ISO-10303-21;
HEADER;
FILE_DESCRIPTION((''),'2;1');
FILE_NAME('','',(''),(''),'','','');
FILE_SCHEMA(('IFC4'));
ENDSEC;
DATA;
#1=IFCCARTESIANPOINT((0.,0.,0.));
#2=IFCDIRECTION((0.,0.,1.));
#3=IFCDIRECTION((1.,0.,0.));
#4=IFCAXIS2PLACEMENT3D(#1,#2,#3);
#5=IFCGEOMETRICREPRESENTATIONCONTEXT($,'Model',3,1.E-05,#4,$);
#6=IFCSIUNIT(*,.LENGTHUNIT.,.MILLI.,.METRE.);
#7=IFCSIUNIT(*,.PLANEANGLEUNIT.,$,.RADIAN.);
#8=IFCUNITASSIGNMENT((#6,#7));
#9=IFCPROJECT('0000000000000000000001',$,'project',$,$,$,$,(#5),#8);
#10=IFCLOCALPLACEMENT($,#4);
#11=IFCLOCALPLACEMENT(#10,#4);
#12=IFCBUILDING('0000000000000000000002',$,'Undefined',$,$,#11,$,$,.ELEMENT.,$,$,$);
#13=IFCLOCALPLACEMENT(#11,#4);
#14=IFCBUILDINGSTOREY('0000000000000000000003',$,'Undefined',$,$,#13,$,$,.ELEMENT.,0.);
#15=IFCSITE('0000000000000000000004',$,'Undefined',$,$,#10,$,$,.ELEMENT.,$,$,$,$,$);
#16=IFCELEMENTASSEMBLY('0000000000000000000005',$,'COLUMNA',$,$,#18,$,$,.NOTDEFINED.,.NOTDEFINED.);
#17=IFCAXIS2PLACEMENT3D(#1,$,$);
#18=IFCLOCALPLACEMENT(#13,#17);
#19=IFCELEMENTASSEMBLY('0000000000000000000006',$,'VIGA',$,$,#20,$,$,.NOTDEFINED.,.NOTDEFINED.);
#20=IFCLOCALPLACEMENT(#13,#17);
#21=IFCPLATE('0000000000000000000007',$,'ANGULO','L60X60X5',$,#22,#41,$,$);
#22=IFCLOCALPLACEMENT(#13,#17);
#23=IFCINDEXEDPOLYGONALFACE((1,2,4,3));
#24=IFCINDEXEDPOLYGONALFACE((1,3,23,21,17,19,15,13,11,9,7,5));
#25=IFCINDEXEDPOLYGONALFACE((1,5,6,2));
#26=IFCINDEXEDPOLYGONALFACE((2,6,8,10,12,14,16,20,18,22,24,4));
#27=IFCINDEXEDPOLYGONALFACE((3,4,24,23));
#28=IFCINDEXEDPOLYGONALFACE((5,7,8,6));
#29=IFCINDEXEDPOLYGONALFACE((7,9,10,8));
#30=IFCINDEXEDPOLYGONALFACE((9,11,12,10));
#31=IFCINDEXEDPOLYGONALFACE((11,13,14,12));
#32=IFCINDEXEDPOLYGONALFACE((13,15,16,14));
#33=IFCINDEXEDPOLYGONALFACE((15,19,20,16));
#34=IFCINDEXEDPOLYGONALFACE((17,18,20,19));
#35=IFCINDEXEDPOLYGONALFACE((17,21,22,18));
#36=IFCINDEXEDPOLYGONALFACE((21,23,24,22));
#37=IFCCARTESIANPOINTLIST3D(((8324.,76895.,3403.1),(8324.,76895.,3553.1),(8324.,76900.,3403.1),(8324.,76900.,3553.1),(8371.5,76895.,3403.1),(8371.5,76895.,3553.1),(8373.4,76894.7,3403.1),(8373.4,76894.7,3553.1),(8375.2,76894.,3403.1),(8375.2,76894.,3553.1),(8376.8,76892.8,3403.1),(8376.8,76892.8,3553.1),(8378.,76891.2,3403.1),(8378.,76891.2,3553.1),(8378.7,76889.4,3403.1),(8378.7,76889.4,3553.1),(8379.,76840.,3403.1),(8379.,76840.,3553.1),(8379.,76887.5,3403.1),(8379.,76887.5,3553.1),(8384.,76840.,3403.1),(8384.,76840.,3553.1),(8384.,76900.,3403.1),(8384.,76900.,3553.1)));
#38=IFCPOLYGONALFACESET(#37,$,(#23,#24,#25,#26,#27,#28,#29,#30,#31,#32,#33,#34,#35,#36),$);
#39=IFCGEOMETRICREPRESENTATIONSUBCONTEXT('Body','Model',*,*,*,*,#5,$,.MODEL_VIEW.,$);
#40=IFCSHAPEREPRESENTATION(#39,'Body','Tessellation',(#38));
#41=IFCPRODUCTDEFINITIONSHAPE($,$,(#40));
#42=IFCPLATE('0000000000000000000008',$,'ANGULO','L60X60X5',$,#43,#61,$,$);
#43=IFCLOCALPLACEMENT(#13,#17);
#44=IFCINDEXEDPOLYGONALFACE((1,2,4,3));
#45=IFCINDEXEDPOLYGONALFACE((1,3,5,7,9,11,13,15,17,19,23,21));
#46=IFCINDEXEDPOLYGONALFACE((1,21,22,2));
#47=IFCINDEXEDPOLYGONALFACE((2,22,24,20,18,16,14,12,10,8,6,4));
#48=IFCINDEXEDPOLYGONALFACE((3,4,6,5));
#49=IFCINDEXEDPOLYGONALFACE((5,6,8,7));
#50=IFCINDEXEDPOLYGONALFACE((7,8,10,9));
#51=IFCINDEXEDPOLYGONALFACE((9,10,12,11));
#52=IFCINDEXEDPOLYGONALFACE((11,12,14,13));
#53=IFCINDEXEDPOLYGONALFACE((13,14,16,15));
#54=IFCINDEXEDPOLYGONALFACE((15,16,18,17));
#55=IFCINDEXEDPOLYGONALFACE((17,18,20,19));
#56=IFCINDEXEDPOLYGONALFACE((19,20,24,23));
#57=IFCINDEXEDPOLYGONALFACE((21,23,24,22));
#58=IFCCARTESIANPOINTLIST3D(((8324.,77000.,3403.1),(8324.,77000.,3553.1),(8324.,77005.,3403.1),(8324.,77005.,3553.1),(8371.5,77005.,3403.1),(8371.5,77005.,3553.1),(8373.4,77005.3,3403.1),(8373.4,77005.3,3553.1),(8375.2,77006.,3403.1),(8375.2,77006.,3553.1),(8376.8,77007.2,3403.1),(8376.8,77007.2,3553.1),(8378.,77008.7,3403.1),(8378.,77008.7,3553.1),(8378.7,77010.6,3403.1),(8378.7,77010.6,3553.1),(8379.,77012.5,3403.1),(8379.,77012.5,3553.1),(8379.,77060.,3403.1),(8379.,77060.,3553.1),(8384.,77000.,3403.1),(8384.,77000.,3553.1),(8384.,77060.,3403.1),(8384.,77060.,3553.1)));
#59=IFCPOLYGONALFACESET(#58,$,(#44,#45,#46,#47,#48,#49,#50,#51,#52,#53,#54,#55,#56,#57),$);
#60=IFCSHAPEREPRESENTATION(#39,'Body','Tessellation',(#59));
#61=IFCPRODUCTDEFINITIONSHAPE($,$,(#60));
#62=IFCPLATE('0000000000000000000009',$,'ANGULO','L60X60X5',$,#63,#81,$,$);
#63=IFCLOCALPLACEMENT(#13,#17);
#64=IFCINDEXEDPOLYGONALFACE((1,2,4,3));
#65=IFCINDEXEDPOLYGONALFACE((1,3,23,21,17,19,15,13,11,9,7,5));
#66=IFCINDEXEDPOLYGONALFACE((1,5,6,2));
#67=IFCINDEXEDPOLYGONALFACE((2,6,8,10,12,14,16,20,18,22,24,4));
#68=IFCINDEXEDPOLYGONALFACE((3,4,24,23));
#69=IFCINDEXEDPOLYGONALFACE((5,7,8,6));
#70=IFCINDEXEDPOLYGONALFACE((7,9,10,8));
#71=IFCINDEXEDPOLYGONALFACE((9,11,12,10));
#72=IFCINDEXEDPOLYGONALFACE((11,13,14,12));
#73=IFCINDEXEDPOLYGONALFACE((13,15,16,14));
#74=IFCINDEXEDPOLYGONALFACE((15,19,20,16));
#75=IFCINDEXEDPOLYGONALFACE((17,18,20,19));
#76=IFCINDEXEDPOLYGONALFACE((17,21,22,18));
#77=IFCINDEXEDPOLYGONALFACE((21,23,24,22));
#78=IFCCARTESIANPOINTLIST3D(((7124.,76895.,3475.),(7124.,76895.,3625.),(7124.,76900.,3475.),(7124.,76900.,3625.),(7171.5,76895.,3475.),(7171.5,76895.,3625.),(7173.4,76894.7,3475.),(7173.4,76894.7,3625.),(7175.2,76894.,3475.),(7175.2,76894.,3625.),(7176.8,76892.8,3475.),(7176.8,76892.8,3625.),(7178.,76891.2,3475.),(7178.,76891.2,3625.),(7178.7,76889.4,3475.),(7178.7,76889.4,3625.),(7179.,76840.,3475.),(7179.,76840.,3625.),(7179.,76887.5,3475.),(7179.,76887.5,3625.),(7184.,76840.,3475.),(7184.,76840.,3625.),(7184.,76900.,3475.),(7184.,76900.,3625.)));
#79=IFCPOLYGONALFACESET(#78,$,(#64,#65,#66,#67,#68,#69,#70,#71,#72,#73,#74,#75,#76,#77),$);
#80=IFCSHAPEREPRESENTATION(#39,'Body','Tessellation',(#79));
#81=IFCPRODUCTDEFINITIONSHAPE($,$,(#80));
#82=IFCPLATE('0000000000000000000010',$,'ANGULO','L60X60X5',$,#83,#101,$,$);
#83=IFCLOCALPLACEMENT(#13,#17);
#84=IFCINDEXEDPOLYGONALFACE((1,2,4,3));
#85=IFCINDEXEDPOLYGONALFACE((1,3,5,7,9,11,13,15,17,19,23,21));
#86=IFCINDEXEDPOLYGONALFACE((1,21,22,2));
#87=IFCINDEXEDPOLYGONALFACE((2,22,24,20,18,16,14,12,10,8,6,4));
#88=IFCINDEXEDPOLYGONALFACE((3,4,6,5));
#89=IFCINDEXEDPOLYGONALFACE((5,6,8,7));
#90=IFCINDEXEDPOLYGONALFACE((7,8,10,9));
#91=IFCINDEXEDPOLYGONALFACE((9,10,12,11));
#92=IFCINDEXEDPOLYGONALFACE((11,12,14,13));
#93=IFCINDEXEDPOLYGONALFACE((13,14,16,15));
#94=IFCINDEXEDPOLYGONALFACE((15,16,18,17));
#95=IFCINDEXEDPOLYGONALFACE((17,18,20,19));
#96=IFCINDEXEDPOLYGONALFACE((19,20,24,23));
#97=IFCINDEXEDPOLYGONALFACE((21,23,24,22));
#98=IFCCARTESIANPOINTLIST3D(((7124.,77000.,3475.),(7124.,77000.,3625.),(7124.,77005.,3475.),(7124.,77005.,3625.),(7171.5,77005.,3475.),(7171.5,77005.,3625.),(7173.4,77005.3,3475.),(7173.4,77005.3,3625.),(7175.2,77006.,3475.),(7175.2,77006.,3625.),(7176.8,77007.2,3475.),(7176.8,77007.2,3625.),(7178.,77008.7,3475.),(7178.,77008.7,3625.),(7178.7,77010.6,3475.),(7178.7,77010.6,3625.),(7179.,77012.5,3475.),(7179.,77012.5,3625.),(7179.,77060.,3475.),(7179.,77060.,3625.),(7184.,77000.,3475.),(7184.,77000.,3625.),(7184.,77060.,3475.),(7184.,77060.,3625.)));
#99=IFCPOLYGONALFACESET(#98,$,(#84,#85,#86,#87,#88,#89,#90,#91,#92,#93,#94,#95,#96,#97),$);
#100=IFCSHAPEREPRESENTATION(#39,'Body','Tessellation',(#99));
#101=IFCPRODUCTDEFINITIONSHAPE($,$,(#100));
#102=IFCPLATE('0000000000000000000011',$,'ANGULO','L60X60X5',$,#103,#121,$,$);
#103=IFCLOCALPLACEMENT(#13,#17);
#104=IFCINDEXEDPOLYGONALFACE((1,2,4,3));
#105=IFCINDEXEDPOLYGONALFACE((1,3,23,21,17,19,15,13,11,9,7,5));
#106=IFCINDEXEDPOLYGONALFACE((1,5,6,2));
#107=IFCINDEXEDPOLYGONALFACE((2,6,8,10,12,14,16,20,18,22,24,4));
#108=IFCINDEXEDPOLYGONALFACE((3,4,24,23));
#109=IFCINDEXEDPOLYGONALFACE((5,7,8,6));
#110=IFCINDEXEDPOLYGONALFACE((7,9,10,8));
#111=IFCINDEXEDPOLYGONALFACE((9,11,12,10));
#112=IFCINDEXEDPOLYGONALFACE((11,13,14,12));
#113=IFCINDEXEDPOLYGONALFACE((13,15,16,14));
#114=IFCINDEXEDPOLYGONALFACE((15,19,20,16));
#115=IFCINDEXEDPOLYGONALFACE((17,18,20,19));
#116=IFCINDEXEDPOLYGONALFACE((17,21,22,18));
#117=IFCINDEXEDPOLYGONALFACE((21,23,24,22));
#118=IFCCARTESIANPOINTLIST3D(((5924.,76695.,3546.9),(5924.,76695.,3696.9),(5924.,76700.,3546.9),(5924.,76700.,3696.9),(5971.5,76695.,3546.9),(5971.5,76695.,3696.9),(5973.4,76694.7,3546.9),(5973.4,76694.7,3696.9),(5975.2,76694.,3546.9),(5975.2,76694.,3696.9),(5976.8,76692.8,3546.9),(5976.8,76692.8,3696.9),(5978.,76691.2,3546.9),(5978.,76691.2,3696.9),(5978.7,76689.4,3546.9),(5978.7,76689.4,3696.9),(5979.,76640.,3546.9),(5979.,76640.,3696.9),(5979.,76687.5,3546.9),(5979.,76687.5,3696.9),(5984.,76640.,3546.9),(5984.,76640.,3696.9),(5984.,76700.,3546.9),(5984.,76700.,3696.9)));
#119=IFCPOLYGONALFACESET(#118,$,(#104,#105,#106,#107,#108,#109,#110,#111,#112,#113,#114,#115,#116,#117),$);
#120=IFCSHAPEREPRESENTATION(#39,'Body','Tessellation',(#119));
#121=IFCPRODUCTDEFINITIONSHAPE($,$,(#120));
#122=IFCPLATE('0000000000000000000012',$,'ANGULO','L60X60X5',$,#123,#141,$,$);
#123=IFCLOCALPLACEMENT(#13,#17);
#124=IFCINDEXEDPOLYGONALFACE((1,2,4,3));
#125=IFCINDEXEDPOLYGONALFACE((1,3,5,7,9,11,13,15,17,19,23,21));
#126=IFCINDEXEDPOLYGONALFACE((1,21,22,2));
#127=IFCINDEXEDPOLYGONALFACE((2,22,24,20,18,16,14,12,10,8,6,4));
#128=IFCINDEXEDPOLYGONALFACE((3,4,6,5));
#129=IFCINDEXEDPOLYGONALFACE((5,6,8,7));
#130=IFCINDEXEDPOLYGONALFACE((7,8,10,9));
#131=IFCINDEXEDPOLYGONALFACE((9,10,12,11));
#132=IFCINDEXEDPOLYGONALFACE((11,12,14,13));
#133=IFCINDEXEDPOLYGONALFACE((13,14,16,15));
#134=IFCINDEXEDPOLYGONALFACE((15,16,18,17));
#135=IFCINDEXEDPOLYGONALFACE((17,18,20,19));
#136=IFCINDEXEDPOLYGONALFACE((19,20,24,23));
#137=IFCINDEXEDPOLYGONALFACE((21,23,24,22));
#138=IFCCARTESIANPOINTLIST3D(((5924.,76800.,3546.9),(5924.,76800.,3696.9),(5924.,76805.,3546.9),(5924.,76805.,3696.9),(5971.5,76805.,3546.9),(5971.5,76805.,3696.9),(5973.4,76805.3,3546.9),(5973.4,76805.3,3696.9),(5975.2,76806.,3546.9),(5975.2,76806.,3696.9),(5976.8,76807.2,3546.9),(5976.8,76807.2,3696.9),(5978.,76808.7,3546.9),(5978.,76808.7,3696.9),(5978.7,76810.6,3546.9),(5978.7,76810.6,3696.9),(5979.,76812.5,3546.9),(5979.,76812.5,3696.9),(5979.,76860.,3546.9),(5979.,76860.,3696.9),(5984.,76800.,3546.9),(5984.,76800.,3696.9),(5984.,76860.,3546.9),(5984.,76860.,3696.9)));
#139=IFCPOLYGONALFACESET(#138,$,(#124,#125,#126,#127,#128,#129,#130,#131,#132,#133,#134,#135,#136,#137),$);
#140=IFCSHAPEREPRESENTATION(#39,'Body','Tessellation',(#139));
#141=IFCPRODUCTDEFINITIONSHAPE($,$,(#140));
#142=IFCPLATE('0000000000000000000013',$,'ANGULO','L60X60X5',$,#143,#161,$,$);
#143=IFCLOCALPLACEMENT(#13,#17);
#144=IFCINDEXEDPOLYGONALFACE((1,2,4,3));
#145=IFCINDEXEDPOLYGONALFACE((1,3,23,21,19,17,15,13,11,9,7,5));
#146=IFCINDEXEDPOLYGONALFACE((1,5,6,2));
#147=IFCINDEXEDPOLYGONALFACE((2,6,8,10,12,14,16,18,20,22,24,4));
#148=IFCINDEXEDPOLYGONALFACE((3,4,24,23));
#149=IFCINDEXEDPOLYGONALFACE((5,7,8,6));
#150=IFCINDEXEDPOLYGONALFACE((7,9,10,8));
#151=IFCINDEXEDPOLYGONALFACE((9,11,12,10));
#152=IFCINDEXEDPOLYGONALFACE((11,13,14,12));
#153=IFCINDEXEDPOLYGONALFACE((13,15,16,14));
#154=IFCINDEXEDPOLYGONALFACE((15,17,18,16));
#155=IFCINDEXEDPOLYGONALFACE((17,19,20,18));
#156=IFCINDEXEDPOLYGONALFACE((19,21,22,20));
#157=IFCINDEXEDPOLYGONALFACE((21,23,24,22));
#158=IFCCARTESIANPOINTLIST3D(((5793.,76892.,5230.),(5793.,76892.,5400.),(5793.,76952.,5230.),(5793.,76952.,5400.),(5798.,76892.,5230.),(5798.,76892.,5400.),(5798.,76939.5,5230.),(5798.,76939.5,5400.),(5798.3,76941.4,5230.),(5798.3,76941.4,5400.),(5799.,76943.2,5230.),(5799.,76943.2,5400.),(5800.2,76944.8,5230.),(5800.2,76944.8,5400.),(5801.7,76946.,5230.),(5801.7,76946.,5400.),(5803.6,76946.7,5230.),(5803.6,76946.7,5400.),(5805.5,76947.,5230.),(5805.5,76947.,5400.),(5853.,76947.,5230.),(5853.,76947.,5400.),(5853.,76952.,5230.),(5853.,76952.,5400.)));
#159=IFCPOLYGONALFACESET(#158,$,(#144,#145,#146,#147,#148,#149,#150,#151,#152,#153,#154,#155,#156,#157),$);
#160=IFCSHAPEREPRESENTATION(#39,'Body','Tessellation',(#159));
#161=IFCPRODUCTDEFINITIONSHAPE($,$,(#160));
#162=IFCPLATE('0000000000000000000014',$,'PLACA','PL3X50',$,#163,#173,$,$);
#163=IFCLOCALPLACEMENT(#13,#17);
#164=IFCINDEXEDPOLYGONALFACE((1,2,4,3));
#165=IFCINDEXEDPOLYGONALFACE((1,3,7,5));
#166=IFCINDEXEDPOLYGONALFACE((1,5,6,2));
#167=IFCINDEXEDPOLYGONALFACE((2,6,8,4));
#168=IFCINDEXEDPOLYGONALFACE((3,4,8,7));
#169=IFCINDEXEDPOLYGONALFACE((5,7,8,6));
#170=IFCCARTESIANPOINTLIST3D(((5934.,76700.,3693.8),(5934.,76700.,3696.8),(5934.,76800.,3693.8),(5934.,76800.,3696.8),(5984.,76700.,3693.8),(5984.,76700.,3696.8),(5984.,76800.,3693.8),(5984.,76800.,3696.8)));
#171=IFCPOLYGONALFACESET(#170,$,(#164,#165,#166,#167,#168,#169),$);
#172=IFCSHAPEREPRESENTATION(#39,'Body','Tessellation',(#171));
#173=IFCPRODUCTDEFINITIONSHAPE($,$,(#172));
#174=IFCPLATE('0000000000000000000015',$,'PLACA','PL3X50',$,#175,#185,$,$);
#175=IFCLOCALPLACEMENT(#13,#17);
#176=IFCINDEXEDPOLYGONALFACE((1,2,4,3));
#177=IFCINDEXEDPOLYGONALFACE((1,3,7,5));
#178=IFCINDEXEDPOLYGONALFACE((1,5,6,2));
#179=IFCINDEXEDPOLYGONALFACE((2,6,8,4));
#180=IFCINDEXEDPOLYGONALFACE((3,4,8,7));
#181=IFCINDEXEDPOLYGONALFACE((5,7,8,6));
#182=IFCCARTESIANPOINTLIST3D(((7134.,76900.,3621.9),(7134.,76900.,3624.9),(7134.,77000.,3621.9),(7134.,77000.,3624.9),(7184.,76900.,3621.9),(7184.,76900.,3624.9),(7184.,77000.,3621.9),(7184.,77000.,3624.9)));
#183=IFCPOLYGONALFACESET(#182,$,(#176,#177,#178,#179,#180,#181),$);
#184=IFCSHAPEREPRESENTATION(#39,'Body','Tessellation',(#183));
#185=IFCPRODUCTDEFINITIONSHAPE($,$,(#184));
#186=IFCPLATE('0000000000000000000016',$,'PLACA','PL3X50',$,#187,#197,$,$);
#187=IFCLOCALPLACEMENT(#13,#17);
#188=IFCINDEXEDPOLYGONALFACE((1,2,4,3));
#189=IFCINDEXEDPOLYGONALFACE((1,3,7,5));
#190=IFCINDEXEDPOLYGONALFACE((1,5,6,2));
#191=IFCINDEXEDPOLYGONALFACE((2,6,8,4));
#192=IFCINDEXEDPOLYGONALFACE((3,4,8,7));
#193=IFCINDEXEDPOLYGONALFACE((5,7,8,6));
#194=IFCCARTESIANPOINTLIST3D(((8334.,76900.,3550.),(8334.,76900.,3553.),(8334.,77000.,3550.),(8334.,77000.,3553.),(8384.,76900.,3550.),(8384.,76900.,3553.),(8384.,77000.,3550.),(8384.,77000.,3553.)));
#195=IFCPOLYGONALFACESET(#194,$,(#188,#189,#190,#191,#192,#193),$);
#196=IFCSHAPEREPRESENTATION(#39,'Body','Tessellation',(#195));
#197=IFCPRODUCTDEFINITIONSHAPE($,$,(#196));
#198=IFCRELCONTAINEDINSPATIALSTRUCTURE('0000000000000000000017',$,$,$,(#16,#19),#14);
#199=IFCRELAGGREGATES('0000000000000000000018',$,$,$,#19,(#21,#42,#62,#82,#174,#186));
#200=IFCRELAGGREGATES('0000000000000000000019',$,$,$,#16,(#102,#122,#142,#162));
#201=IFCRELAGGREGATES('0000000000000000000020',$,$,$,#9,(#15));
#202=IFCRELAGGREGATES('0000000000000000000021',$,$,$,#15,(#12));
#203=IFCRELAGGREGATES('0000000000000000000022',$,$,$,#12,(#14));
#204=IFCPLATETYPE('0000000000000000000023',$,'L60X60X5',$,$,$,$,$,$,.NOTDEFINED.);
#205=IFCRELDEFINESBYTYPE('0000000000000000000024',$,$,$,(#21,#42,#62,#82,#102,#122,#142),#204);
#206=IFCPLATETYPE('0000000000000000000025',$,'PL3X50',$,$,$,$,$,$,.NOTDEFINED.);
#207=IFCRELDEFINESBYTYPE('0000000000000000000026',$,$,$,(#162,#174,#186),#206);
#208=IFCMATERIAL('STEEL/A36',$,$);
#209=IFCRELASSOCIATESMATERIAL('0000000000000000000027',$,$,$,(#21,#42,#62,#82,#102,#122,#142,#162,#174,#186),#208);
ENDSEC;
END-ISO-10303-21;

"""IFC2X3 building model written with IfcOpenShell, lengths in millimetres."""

from ifc_helpers import new_model, si_unit, frame, origin_with_axes, origin_2d_with_axis, place, context, subcontext, project, spatial, polyline, l_section, outline, extrude, material, type_object, element, aggregate, save


model = new_model("IFC2X3")

# Units and contexts
model_context = context("Model", 3, precision=1e-05, world=origin_with_axes())
body_context = subcontext(model_context, "Body", "Model", "MODEL_VIEW")
ifc_project = project(units=[si_unit("LENGTHUNIT", "METRE", prefix="MILLI"), si_unit("PLANEANGLEUNIT", "RADIAN")], contexts=[model_context])

# Site, building, storey
site_placement = place(None, origin_with_axes())
site = spatial("IfcSite", under=ifc_project, at=site_placement, Name="Undefined", CompositionType="ELEMENT")
building_placement = place(site_placement, origin_with_axes())
building = spatial("IfcBuilding", under=site, at=building_placement, Name="Undefined", CompositionType="ELEMENT")
storey_placement = place(building_placement, origin_with_axes())
storey = spatial("IfcBuildingStorey", under=building, at=storey_placement, Name="Undefined", CompositionType="ELEMENT", Elevation=0.0)

# Element assembly
assembly_1_placement = place(storey_placement, origin_with_axes())
assembly_1 = element("IfcElementAssembly", 1, at=assembly_1_placement, inside=storey, Name="COLUMNA", AssemblyPlace="NOTDEFINED", PredefinedType="NOTDEFINED")
ifc_material_1 = material(Name="STEEL/A36")

# Element assembly, plates
assembly_2_placement = place(storey_placement, origin_with_axes())
assembly_2 = element("IfcElementAssembly", 2, at=assembly_2_placement, inside=storey, Name="VIGA", AssemblyPlace="NOTDEFINED", PredefinedType="NOTDEFINED")
plate_type_1 = type_object("IfcPlateType", Name="L60X60X5", PredefinedType="NOTDEFINED")
plate_1_placement = place(assembly_2_placement, frame((8354.0, 76870.0, 3403.1), z_axis=(-1.0, 0.0, 0.0), x_axis=(0.0, 0.0, 1.0)))
plate_1 = element("IfcPlate", 3, at=plate_1_placement, type_object=plate_type_1, material=ifc_material_1, Name="ANGULO", Description="L60X60X5", context=body_context, shape_type="SweptSolid", body=[
    extrude(l_section(Depth=60.0, Width=60.0, Thickness=5.0, FilletRadius=7.5, at=origin_2d_with_axis()), frame((150.0, 0.0, 0.0), z_axis=(-1.0, 0.0, 0.0), x_axis=(0.0, -1.0, 0.0)), (0.0, 0.0, 1.0), 150.0),
])
plate_2_placement = place(assembly_2_placement, frame((8354.0, 77030.0, 3553.1), z_axis=(-1.0, 0.0, 0.0), x_axis=(0.0, 0.0, -1.0)))
plate_2 = element("IfcPlate", 4, at=plate_2_placement, type_object=plate_type_1, material=ifc_material_1, Name="ANGULO", Description="L60X60X5", context=body_context, shape_type="SweptSolid", body=[
    extrude(l_section(Depth=60.0, Width=60.0, Thickness=5.0, FilletRadius=7.5, at=origin_2d_with_axis()), frame((150.0, 0.0, 0.0), z_axis=(-1.0, 0.0, 0.0), x_axis=(0.0, -1.0, 0.0)), (0.0, 0.0, 1.0), 150.0),
])
plate_3_placement = place(assembly_2_placement, frame((7154.0, 76870.0, 3475.0), z_axis=(-1.0, 0.0, 0.0), x_axis=(0.0, 0.0, 1.0)))
plate_3 = element("IfcPlate", 5, at=plate_3_placement, type_object=plate_type_1, material=ifc_material_1, Name="ANGULO", Description="L60X60X5", context=body_context, shape_type="SweptSolid", body=[
    extrude(l_section(Depth=60.0, Width=60.0, Thickness=5.0, FilletRadius=7.5, at=origin_2d_with_axis()), frame((150.0, 0.0, 0.0), z_axis=(-1.0, 0.0, 0.0), x_axis=(0.0, -1.0, 0.0)), (0.0, 0.0, 1.0), 150.0),
])
plate_4_placement = place(assembly_2_placement, frame((7154.0, 77030.0, 3625.0), z_axis=(-1.0, 0.0, 0.0), x_axis=(0.0, 0.0, -1.0)))
plate_4 = element("IfcPlate", 6, at=plate_4_placement, type_object=plate_type_1, material=ifc_material_1, Name="ANGULO", Description="L60X60X5", context=body_context, shape_type="SweptSolid", body=[
    extrude(l_section(Depth=60.0, Width=60.0, Thickness=5.0, FilletRadius=7.5, at=origin_2d_with_axis()), frame((150.0, 0.0, 0.0), z_axis=(-1.0, 0.0, 0.0), x_axis=(0.0, -1.0, 0.0)), (0.0, 0.0, 1.0), 150.0),
])

# Plates
plate_5_placement = place(assembly_1_placement, frame((5954.0, 76670.0, 3546.9), z_axis=(-1.0, 0.0, 0.0), x_axis=(0.0, 0.0, 1.0)))
plate_5 = element("IfcPlate", 7, at=plate_5_placement, type_object=plate_type_1, material=ifc_material_1, Name="ANGULO", Description="L60X60X5", context=body_context, shape_type="SweptSolid", body=[
    extrude(l_section(Depth=60.0, Width=60.0, Thickness=5.0, FilletRadius=7.5, at=origin_2d_with_axis()), frame((150.0, 0.0, 0.0), z_axis=(-1.0, 0.0, 0.0), x_axis=(0.0, -1.0, 0.0)), (0.0, 0.0, 1.0), 150.0),
])
plate_6_placement = place(assembly_1_placement, frame((5954.0, 76830.0, 3696.9), z_axis=(-1.0, 0.0, 0.0), x_axis=(0.0, 0.0, -1.0)))
plate_6 = element("IfcPlate", 8, at=plate_6_placement, type_object=plate_type_1, material=ifc_material_1, Name="ANGULO", Description="L60X60X5", context=body_context, shape_type="SweptSolid", body=[
    extrude(l_section(Depth=60.0, Width=60.0, Thickness=5.0, FilletRadius=7.5, at=origin_2d_with_axis()), frame((150.0, 0.0, 0.0), z_axis=(-1.0, 0.0, 0.0), x_axis=(0.0, -1.0, 0.0)), (0.0, 0.0, 1.0), 150.0),
])
plate_7_placement = place(assembly_1_placement, frame((5823.0, 76922.0, 5400.0), z_axis=(1.0, 0.0, 0.0), x_axis=(0.0, 0.0, -1.0)))
plate_7 = element("IfcPlate", 9, at=plate_7_placement, type_object=plate_type_1, material=ifc_material_1, Name="ANGULO", Description="L60X60X5", context=body_context, shape_type="SweptSolid", body=[
    extrude(l_section(Depth=60.0, Width=60.0, Thickness=5.0, FilletRadius=7.5, at=origin_2d_with_axis()), frame((170.0, 0.0, 0.0), z_axis=(-1.0, 0.0, 0.0), x_axis=(0.0, -1.0, 0.0)), (0.0, 0.0, 1.0), 170.0),
])
plate_type_2 = type_object("IfcPlateType", Name="PL3X50", PredefinedType="NOTDEFINED")
plate_8_placement = place(assembly_1_placement, frame((5984.0, 76700.0, 3695.3), z_axis=(0.0, 0.0, -1.0), x_axis=(-1.0, 0.0, 0.0)))
plate_8 = element("IfcPlate", 10, at=plate_8_placement, type_object=plate_type_2, material=ifc_material_1, Name="PLACA", Description="PL3X50", context=body_context, shape_type="SweptSolid", body=[
    extrude(outline(polyline([(0.0, 0.0), (50.0, 0.0), (50.0, 100.0), (0.0, 100.0), (0.0, 0.0)])), frame((0.0, 0.0, -1.5), z_axis=(0.0, 0.0, 1.0), x_axis=(1.0, 0.0, 0.0)), (0.0, 0.0, 1.0), 3.0),
])
plate_9_placement = place(assembly_2_placement, frame((7184.0, 76900.0, 3623.4), z_axis=(0.0, 0.0, -1.0), x_axis=(-1.0, 0.0, 0.0)))
plate_9 = element("IfcPlate", 11, at=plate_9_placement, type_object=plate_type_2, material=ifc_material_1, Name="PLACA", Description="PL3X50", context=body_context, shape_type="SweptSolid", body=[
    extrude(outline(polyline([(0.0, 0.0), (50.0, 0.0), (50.0, 100.0), (0.0, 100.0), (0.0, 0.0)])), frame((0.0, 0.0, -1.5), z_axis=(0.0, 0.0, 1.0), x_axis=(1.0, 0.0, 0.0)), (0.0, 0.0, 1.0), 3.0),
])
plate_10_placement = place(assembly_2_placement, frame((8384.0, 76900.0, 3551.5), z_axis=(0.0, 0.0, -1.0), x_axis=(-1.0, 0.0, 0.0)))
plate_10 = element("IfcPlate", 12, at=plate_10_placement, type_object=plate_type_2, material=ifc_material_1, Name="PLACA", Description="PL3X50", context=body_context, shape_type="SweptSolid", body=[
    extrude(outline(polyline([(0.0, 0.0), (50.0, 0.0), (50.0, 100.0), (0.0, 100.0), (0.0, 0.0)])), frame((0.0, 0.0, -1.5), z_axis=(0.0, 0.0, 1.0), x_axis=(1.0, 0.0, 0.0)), (0.0, 0.0, 1.0), 3.0),
])
aggregate(assembly_2, [plate_1, plate_2, plate_3, plate_4, plate_9, plate_10])

aggregate(assembly_1, [plate_5, plate_6, plate_7, plate_8])

save(model, "model.ifc")
